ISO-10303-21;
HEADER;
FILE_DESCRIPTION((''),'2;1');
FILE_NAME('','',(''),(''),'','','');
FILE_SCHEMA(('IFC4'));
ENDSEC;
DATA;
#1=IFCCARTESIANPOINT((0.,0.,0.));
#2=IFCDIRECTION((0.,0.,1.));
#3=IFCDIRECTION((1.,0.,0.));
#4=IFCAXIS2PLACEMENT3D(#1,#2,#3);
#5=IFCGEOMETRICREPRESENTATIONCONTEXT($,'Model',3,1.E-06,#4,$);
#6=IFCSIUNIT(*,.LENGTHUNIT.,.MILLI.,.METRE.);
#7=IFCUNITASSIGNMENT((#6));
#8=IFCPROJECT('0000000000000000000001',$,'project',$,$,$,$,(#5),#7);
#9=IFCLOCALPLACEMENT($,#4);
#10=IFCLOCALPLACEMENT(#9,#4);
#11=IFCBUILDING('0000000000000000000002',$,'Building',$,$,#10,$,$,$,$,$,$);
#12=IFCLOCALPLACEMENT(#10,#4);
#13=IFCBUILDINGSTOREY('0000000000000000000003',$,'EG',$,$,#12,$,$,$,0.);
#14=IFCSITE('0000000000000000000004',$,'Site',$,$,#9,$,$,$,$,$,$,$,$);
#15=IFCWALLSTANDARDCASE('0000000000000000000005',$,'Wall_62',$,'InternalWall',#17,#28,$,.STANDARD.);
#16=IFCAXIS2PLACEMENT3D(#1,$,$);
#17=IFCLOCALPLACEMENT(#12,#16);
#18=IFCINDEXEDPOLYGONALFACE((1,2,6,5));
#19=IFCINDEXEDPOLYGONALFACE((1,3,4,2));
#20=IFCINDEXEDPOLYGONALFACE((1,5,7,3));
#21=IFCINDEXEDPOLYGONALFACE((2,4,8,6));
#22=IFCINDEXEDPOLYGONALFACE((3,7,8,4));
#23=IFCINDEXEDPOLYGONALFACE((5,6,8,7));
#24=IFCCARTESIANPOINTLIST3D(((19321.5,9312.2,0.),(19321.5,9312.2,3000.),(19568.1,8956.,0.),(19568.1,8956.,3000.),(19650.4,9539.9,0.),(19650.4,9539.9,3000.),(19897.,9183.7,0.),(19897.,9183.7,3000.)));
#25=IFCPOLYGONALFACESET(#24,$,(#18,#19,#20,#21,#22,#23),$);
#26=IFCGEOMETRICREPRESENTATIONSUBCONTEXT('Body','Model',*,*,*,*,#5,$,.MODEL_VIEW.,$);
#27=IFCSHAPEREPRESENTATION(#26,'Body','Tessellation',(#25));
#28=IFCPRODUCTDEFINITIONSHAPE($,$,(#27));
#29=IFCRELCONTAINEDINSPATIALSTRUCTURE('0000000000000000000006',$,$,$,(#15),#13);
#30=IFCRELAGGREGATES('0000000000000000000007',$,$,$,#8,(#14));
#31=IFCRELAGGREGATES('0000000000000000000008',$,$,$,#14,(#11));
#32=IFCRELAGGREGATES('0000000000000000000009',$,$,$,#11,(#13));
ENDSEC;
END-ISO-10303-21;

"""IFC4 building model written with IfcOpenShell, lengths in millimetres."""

from ifc_helpers import new_model, si_unit, frame, origin_with_axes, place, context, subcontext, project, spatial, rectangle, extrude, element, save


model = new_model("IFC4")

# Units and contexts
model_context = context("Model", 3, precision=1e-06, world=origin_with_axes())
body_context = subcontext(model_context, "Body", "Model", "MODEL_VIEW")
ifc_project = project(units=[si_unit("LENGTHUNIT", "METRE", prefix="MILLI")], contexts=[model_context])

# Site, building, storey
site_placement = place(None, origin_with_axes())
site = spatial("IfcSite", under=ifc_project, at=site_placement, Name="Site")
building_placement = place(site_placement, origin_with_axes())
building = spatial("IfcBuilding", under=site, at=building_placement, Name="Building")
storey_placement = place(building_placement, origin_with_axes())
storey = spatial("IfcBuildingStorey", under=building, at=storey_placement, Name="EG", Elevation=0.0)

# Wall
wall_1_placement = place(storey_placement, origin_with_axes())
element("IfcWallStandardCase", 1, at=wall_1_placement, inside=storey, Name="Wall_62", ObjectType="InternalWall", PredefinedType="STANDARD", context=body_context, shape_type="SweptSolid", body=[
    extrude(rectangle(XDim=433.2, YDim=400.0), frame((19609.2, 9247.9, 0.0), z_axis=(0.0, 0.0, 1.0), x_axis=(-0.56921, 0.822192, 0.0)), (0.0, 0.0, 1.0), 3000.0),
])

save(model, "model.ifc")
